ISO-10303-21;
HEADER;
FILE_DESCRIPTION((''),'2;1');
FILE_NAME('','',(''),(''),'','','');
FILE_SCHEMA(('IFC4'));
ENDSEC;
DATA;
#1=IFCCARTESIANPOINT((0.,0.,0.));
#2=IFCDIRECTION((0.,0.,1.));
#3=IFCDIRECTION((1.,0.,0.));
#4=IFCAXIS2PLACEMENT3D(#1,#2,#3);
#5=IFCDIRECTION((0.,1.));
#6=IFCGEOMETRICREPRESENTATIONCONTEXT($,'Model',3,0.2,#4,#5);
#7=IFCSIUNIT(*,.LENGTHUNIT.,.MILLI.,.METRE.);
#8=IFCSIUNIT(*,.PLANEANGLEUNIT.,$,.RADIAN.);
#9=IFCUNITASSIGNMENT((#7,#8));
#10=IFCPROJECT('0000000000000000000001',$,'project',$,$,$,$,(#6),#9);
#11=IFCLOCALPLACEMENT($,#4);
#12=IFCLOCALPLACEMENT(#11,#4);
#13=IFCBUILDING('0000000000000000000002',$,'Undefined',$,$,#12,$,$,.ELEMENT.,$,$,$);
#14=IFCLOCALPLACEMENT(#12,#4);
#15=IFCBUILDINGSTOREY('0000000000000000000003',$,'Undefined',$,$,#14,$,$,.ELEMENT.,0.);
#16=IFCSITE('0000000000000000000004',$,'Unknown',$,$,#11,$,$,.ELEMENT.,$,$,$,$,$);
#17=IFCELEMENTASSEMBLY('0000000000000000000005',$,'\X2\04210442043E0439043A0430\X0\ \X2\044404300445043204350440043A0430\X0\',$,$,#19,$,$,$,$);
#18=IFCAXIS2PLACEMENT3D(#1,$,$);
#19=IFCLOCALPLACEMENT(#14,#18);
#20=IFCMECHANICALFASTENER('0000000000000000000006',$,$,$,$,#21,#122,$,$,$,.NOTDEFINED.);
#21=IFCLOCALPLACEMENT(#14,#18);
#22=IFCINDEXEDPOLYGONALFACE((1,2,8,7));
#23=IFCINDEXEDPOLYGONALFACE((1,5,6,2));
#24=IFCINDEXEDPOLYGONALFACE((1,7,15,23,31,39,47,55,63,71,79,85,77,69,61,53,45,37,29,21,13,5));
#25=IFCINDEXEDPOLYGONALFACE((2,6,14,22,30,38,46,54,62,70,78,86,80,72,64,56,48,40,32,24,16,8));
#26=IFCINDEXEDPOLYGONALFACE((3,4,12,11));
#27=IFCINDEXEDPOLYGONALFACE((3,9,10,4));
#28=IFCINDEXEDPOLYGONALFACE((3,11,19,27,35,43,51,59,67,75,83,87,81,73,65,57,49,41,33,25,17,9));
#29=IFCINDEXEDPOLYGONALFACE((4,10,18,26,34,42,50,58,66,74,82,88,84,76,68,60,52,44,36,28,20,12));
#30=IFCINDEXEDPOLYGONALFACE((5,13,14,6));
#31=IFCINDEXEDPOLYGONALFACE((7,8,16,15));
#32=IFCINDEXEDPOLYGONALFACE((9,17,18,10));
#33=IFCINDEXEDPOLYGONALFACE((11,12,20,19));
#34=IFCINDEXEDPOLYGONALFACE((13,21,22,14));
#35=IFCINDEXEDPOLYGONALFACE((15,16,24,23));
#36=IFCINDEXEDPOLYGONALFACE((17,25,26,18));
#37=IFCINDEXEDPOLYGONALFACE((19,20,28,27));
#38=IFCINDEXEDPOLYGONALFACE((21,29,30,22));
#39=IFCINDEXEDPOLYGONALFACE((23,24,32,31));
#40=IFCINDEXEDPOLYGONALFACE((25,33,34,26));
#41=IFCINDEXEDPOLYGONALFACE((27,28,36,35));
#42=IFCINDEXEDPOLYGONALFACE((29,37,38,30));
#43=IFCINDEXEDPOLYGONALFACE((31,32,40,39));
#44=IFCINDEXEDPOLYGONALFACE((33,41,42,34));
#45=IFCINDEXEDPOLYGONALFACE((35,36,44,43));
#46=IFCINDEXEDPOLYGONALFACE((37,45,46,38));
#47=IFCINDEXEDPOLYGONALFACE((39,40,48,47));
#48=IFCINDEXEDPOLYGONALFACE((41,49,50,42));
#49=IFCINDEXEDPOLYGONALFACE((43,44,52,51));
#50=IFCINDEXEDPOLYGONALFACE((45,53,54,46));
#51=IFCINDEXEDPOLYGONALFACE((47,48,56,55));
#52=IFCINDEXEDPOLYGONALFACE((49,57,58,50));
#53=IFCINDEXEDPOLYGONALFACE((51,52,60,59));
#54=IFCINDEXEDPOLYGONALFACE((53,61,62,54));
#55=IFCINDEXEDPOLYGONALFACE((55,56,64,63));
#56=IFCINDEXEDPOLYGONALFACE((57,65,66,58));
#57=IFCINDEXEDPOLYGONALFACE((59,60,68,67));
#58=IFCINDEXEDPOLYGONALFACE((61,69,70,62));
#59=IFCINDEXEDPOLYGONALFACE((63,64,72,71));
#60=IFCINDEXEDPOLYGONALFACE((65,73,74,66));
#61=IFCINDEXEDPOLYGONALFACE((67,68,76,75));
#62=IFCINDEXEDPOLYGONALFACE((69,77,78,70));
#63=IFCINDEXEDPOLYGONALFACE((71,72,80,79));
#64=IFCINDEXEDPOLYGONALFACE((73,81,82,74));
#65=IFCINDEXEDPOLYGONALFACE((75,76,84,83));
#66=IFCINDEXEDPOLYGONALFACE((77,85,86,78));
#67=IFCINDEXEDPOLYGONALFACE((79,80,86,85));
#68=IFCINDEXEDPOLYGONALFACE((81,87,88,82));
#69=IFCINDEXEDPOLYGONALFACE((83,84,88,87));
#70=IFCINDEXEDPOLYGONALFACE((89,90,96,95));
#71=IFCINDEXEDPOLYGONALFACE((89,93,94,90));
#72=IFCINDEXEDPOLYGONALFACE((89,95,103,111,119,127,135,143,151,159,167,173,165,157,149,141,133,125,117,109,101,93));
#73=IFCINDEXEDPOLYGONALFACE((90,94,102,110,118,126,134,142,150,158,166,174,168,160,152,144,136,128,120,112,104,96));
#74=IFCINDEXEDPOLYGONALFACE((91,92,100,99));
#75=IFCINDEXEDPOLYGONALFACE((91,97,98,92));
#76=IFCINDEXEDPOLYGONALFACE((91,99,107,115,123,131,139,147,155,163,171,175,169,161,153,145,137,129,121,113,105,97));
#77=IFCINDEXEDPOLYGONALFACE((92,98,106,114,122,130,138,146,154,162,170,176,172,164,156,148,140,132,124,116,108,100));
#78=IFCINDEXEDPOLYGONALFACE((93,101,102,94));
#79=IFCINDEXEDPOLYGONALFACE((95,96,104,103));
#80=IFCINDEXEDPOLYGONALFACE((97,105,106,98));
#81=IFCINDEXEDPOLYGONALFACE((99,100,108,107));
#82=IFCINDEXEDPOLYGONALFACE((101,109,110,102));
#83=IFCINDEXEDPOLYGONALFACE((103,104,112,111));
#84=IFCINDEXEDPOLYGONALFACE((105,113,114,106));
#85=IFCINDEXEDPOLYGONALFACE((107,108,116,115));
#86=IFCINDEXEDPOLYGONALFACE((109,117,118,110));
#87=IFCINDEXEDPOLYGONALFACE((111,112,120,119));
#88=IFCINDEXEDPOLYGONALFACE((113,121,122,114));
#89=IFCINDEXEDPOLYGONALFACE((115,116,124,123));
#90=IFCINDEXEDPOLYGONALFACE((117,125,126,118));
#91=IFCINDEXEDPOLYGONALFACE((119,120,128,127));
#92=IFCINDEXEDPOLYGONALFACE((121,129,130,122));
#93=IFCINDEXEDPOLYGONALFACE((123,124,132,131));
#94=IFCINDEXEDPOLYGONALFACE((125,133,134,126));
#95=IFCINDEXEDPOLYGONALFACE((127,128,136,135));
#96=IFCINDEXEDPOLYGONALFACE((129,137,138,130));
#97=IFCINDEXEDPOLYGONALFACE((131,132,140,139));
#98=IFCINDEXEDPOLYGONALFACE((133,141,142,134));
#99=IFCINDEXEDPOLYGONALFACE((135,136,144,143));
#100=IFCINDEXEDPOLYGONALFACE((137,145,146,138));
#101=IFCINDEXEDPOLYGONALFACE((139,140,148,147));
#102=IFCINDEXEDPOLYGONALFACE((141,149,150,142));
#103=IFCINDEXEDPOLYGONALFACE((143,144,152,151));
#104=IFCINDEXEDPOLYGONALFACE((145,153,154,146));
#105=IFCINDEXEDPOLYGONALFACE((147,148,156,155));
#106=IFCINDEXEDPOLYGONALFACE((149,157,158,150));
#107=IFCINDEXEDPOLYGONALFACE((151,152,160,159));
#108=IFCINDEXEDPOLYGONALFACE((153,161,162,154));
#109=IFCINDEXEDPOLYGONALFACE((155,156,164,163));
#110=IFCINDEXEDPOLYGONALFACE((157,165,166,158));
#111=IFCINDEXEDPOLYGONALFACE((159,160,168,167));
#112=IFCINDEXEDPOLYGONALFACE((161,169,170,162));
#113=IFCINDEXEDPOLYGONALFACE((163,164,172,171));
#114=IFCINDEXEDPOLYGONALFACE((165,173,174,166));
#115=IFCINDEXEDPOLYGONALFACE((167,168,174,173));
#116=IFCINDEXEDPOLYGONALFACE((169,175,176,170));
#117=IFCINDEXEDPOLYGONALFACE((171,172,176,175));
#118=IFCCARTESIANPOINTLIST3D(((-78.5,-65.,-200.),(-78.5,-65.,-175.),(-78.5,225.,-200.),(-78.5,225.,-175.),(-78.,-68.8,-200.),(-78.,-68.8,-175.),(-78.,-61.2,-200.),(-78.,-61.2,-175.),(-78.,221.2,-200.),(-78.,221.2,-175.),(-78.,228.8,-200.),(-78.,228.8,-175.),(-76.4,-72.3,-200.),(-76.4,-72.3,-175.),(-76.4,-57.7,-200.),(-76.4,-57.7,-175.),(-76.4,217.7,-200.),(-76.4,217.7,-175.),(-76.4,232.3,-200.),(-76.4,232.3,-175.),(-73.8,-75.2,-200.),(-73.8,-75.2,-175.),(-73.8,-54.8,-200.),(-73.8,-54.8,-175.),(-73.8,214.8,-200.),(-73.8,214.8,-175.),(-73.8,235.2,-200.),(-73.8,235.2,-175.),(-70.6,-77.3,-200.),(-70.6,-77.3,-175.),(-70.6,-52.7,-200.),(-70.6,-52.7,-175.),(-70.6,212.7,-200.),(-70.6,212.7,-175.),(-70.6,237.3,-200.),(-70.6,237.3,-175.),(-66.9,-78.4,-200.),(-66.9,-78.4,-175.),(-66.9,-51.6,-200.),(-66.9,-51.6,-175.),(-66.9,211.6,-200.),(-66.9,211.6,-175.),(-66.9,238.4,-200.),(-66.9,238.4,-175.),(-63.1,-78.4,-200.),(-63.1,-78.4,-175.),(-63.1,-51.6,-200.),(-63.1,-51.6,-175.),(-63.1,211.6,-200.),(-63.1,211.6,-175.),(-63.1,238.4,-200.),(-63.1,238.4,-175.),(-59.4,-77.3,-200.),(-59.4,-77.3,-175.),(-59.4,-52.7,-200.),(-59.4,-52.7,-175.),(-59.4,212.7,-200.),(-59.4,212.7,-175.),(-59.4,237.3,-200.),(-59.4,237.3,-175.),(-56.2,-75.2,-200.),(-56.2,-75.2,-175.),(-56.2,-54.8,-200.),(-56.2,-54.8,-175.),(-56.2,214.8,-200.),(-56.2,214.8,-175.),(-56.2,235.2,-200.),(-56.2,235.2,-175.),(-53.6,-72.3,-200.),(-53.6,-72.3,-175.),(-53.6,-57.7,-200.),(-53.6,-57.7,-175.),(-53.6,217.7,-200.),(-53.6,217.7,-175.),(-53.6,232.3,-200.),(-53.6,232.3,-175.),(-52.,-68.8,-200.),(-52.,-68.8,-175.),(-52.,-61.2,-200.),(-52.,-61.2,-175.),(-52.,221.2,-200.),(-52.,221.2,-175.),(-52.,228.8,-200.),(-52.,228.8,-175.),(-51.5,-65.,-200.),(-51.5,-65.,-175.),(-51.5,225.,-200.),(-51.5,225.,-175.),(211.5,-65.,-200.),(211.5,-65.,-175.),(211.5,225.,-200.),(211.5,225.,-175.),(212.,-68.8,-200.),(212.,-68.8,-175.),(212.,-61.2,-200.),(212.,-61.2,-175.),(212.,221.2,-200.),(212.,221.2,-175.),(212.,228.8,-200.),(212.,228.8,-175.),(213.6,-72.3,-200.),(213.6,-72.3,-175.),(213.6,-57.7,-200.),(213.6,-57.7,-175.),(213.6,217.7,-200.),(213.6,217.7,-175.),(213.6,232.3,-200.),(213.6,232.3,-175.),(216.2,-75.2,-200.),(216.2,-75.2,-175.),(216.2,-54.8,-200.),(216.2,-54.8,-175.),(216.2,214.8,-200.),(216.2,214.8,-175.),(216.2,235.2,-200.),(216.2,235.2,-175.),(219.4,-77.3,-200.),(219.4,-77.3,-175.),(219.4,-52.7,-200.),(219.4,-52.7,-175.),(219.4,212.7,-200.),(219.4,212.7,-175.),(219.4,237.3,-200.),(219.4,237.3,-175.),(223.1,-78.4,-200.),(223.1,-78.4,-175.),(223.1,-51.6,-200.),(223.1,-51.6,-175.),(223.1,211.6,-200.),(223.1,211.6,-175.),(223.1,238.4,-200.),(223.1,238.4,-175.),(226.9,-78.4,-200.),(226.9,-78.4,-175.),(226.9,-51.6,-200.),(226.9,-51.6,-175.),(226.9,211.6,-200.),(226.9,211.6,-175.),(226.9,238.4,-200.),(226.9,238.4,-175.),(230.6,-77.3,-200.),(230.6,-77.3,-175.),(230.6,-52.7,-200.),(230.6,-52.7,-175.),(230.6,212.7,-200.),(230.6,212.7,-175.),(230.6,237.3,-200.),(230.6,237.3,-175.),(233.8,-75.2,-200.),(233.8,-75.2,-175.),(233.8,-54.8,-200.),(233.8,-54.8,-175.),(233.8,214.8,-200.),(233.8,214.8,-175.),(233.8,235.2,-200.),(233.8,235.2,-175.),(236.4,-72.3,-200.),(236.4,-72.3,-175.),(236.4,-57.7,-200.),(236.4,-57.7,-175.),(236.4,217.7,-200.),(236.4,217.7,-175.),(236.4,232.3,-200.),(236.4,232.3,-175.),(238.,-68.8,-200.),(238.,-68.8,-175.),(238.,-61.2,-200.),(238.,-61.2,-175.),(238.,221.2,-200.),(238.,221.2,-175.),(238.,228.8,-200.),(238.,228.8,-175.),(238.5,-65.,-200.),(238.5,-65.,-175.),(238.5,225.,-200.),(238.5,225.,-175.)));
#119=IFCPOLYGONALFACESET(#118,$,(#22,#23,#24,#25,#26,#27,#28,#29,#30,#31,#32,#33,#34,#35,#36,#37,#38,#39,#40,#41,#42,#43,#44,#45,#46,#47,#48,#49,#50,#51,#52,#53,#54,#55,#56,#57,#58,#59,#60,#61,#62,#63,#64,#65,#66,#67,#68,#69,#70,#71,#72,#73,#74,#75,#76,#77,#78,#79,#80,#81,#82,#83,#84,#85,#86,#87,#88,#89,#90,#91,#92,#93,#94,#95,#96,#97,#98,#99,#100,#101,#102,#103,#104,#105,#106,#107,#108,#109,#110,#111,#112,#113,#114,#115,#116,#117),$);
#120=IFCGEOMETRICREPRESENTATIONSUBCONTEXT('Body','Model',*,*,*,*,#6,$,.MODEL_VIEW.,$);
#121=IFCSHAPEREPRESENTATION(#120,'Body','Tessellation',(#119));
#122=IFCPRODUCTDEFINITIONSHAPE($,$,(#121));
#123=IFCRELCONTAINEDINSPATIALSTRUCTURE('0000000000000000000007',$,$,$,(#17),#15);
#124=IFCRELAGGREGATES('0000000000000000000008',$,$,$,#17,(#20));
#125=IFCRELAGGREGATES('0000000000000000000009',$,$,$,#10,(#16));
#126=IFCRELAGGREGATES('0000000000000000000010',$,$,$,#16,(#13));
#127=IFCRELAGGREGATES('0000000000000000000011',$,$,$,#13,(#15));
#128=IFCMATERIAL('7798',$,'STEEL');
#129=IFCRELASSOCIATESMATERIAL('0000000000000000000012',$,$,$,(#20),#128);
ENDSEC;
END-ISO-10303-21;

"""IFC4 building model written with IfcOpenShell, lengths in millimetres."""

from ifc_helpers import new_model, si_unit, direction, frame, origin_with_axes, place, context, subcontext, project, spatial, arc, indexed_curve, outline, extrude, source, transform, mapped, material, element, aggregate, save


model = new_model("IFC4")

# Units and contexts
model_context = context("Model", 3, precision=0.2, world=origin_with_axes(), true_north=direction((0.0, 1.0)))
body_context = subcontext(model_context, "Body", "Model", "MODEL_VIEW")
ifc_project = project(units=[si_unit("LENGTHUNIT", "METRE", prefix="MILLI"), si_unit("PLANEANGLEUNIT", "RADIAN")], contexts=[model_context])

# Site, building, storey
site_placement = place(None, origin_with_axes())
site = spatial("IfcSite", under=ifc_project, at=site_placement, Name="Unknown", CompositionType="ELEMENT")
building_placement = place(site_placement, origin_with_axes())
building = spatial("IfcBuilding", under=site, at=building_placement, Name="Undefined", CompositionType="ELEMENT")
storey_placement = place(building_placement, origin_with_axes())
storey = spatial("IfcBuildingStorey", under=building, at=storey_placement, Name="Undefined", CompositionType="ELEMENT", Elevation=0.0)

# Element assembly
assembly_1_placement = place(storey_placement, frame((80.0, 80.0, -200.0), z_axis=(0.0, -1.0, 0.0), x_axis=(0.0, 0.0, 1.0)))
assembly_1 = element("IfcElementAssembly", 1, at=assembly_1_placement, inside=storey, Name="Стойка фахверка")

# Mechanical fastener
ifc_material_1 = material(Name="7798", Category="STEEL")
shared_shape_1 = source(origin_with_axes(), body_context, "Body", "SweptSolid", [
    extrude(outline(indexed_curve([(13.5, 0.0), (0.0, 13.5), (-13.5, 0.0), (0.0, -13.5)], segments=[arc(1, 2, 3), arc(3, 4, 1)])), frame((0.0, 0.0, 0.0), z_axis=(0.0, 0.0, -1.0), x_axis=(0.0, 1.0, 0.0)), (0.0, 0.0, 1.0), 25.0),
])
mechanical_fastener_1_placement = place(assembly_1_placement, frame((25.0, 0.0, 145.0), z_axis=(1.0, 0.0, 0.0), x_axis=(0.0, 0.0, -1.0)))
mechanical_fastener_1 = element("IfcMechanicalFastener", 2, at=mechanical_fastener_1_placement, material=ifc_material_1, PredefinedType="NOTDEFINED", context=body_context, shape_type="MappedRepresentation", body=[
    mapped(shared_shape_1, transform((0.0, -145.0, 0.0))),
    mapped(shared_shape_1, transform((290.0, -145.0, 0.0))),
    mapped(shared_shape_1, transform((0.0, 145.0, 0.0))),
    mapped(shared_shape_1, transform((290.0, 145.0, 0.0))),
])
aggregate(assembly_1, [mechanical_fastener_1])

save(model, "model.ifc")
